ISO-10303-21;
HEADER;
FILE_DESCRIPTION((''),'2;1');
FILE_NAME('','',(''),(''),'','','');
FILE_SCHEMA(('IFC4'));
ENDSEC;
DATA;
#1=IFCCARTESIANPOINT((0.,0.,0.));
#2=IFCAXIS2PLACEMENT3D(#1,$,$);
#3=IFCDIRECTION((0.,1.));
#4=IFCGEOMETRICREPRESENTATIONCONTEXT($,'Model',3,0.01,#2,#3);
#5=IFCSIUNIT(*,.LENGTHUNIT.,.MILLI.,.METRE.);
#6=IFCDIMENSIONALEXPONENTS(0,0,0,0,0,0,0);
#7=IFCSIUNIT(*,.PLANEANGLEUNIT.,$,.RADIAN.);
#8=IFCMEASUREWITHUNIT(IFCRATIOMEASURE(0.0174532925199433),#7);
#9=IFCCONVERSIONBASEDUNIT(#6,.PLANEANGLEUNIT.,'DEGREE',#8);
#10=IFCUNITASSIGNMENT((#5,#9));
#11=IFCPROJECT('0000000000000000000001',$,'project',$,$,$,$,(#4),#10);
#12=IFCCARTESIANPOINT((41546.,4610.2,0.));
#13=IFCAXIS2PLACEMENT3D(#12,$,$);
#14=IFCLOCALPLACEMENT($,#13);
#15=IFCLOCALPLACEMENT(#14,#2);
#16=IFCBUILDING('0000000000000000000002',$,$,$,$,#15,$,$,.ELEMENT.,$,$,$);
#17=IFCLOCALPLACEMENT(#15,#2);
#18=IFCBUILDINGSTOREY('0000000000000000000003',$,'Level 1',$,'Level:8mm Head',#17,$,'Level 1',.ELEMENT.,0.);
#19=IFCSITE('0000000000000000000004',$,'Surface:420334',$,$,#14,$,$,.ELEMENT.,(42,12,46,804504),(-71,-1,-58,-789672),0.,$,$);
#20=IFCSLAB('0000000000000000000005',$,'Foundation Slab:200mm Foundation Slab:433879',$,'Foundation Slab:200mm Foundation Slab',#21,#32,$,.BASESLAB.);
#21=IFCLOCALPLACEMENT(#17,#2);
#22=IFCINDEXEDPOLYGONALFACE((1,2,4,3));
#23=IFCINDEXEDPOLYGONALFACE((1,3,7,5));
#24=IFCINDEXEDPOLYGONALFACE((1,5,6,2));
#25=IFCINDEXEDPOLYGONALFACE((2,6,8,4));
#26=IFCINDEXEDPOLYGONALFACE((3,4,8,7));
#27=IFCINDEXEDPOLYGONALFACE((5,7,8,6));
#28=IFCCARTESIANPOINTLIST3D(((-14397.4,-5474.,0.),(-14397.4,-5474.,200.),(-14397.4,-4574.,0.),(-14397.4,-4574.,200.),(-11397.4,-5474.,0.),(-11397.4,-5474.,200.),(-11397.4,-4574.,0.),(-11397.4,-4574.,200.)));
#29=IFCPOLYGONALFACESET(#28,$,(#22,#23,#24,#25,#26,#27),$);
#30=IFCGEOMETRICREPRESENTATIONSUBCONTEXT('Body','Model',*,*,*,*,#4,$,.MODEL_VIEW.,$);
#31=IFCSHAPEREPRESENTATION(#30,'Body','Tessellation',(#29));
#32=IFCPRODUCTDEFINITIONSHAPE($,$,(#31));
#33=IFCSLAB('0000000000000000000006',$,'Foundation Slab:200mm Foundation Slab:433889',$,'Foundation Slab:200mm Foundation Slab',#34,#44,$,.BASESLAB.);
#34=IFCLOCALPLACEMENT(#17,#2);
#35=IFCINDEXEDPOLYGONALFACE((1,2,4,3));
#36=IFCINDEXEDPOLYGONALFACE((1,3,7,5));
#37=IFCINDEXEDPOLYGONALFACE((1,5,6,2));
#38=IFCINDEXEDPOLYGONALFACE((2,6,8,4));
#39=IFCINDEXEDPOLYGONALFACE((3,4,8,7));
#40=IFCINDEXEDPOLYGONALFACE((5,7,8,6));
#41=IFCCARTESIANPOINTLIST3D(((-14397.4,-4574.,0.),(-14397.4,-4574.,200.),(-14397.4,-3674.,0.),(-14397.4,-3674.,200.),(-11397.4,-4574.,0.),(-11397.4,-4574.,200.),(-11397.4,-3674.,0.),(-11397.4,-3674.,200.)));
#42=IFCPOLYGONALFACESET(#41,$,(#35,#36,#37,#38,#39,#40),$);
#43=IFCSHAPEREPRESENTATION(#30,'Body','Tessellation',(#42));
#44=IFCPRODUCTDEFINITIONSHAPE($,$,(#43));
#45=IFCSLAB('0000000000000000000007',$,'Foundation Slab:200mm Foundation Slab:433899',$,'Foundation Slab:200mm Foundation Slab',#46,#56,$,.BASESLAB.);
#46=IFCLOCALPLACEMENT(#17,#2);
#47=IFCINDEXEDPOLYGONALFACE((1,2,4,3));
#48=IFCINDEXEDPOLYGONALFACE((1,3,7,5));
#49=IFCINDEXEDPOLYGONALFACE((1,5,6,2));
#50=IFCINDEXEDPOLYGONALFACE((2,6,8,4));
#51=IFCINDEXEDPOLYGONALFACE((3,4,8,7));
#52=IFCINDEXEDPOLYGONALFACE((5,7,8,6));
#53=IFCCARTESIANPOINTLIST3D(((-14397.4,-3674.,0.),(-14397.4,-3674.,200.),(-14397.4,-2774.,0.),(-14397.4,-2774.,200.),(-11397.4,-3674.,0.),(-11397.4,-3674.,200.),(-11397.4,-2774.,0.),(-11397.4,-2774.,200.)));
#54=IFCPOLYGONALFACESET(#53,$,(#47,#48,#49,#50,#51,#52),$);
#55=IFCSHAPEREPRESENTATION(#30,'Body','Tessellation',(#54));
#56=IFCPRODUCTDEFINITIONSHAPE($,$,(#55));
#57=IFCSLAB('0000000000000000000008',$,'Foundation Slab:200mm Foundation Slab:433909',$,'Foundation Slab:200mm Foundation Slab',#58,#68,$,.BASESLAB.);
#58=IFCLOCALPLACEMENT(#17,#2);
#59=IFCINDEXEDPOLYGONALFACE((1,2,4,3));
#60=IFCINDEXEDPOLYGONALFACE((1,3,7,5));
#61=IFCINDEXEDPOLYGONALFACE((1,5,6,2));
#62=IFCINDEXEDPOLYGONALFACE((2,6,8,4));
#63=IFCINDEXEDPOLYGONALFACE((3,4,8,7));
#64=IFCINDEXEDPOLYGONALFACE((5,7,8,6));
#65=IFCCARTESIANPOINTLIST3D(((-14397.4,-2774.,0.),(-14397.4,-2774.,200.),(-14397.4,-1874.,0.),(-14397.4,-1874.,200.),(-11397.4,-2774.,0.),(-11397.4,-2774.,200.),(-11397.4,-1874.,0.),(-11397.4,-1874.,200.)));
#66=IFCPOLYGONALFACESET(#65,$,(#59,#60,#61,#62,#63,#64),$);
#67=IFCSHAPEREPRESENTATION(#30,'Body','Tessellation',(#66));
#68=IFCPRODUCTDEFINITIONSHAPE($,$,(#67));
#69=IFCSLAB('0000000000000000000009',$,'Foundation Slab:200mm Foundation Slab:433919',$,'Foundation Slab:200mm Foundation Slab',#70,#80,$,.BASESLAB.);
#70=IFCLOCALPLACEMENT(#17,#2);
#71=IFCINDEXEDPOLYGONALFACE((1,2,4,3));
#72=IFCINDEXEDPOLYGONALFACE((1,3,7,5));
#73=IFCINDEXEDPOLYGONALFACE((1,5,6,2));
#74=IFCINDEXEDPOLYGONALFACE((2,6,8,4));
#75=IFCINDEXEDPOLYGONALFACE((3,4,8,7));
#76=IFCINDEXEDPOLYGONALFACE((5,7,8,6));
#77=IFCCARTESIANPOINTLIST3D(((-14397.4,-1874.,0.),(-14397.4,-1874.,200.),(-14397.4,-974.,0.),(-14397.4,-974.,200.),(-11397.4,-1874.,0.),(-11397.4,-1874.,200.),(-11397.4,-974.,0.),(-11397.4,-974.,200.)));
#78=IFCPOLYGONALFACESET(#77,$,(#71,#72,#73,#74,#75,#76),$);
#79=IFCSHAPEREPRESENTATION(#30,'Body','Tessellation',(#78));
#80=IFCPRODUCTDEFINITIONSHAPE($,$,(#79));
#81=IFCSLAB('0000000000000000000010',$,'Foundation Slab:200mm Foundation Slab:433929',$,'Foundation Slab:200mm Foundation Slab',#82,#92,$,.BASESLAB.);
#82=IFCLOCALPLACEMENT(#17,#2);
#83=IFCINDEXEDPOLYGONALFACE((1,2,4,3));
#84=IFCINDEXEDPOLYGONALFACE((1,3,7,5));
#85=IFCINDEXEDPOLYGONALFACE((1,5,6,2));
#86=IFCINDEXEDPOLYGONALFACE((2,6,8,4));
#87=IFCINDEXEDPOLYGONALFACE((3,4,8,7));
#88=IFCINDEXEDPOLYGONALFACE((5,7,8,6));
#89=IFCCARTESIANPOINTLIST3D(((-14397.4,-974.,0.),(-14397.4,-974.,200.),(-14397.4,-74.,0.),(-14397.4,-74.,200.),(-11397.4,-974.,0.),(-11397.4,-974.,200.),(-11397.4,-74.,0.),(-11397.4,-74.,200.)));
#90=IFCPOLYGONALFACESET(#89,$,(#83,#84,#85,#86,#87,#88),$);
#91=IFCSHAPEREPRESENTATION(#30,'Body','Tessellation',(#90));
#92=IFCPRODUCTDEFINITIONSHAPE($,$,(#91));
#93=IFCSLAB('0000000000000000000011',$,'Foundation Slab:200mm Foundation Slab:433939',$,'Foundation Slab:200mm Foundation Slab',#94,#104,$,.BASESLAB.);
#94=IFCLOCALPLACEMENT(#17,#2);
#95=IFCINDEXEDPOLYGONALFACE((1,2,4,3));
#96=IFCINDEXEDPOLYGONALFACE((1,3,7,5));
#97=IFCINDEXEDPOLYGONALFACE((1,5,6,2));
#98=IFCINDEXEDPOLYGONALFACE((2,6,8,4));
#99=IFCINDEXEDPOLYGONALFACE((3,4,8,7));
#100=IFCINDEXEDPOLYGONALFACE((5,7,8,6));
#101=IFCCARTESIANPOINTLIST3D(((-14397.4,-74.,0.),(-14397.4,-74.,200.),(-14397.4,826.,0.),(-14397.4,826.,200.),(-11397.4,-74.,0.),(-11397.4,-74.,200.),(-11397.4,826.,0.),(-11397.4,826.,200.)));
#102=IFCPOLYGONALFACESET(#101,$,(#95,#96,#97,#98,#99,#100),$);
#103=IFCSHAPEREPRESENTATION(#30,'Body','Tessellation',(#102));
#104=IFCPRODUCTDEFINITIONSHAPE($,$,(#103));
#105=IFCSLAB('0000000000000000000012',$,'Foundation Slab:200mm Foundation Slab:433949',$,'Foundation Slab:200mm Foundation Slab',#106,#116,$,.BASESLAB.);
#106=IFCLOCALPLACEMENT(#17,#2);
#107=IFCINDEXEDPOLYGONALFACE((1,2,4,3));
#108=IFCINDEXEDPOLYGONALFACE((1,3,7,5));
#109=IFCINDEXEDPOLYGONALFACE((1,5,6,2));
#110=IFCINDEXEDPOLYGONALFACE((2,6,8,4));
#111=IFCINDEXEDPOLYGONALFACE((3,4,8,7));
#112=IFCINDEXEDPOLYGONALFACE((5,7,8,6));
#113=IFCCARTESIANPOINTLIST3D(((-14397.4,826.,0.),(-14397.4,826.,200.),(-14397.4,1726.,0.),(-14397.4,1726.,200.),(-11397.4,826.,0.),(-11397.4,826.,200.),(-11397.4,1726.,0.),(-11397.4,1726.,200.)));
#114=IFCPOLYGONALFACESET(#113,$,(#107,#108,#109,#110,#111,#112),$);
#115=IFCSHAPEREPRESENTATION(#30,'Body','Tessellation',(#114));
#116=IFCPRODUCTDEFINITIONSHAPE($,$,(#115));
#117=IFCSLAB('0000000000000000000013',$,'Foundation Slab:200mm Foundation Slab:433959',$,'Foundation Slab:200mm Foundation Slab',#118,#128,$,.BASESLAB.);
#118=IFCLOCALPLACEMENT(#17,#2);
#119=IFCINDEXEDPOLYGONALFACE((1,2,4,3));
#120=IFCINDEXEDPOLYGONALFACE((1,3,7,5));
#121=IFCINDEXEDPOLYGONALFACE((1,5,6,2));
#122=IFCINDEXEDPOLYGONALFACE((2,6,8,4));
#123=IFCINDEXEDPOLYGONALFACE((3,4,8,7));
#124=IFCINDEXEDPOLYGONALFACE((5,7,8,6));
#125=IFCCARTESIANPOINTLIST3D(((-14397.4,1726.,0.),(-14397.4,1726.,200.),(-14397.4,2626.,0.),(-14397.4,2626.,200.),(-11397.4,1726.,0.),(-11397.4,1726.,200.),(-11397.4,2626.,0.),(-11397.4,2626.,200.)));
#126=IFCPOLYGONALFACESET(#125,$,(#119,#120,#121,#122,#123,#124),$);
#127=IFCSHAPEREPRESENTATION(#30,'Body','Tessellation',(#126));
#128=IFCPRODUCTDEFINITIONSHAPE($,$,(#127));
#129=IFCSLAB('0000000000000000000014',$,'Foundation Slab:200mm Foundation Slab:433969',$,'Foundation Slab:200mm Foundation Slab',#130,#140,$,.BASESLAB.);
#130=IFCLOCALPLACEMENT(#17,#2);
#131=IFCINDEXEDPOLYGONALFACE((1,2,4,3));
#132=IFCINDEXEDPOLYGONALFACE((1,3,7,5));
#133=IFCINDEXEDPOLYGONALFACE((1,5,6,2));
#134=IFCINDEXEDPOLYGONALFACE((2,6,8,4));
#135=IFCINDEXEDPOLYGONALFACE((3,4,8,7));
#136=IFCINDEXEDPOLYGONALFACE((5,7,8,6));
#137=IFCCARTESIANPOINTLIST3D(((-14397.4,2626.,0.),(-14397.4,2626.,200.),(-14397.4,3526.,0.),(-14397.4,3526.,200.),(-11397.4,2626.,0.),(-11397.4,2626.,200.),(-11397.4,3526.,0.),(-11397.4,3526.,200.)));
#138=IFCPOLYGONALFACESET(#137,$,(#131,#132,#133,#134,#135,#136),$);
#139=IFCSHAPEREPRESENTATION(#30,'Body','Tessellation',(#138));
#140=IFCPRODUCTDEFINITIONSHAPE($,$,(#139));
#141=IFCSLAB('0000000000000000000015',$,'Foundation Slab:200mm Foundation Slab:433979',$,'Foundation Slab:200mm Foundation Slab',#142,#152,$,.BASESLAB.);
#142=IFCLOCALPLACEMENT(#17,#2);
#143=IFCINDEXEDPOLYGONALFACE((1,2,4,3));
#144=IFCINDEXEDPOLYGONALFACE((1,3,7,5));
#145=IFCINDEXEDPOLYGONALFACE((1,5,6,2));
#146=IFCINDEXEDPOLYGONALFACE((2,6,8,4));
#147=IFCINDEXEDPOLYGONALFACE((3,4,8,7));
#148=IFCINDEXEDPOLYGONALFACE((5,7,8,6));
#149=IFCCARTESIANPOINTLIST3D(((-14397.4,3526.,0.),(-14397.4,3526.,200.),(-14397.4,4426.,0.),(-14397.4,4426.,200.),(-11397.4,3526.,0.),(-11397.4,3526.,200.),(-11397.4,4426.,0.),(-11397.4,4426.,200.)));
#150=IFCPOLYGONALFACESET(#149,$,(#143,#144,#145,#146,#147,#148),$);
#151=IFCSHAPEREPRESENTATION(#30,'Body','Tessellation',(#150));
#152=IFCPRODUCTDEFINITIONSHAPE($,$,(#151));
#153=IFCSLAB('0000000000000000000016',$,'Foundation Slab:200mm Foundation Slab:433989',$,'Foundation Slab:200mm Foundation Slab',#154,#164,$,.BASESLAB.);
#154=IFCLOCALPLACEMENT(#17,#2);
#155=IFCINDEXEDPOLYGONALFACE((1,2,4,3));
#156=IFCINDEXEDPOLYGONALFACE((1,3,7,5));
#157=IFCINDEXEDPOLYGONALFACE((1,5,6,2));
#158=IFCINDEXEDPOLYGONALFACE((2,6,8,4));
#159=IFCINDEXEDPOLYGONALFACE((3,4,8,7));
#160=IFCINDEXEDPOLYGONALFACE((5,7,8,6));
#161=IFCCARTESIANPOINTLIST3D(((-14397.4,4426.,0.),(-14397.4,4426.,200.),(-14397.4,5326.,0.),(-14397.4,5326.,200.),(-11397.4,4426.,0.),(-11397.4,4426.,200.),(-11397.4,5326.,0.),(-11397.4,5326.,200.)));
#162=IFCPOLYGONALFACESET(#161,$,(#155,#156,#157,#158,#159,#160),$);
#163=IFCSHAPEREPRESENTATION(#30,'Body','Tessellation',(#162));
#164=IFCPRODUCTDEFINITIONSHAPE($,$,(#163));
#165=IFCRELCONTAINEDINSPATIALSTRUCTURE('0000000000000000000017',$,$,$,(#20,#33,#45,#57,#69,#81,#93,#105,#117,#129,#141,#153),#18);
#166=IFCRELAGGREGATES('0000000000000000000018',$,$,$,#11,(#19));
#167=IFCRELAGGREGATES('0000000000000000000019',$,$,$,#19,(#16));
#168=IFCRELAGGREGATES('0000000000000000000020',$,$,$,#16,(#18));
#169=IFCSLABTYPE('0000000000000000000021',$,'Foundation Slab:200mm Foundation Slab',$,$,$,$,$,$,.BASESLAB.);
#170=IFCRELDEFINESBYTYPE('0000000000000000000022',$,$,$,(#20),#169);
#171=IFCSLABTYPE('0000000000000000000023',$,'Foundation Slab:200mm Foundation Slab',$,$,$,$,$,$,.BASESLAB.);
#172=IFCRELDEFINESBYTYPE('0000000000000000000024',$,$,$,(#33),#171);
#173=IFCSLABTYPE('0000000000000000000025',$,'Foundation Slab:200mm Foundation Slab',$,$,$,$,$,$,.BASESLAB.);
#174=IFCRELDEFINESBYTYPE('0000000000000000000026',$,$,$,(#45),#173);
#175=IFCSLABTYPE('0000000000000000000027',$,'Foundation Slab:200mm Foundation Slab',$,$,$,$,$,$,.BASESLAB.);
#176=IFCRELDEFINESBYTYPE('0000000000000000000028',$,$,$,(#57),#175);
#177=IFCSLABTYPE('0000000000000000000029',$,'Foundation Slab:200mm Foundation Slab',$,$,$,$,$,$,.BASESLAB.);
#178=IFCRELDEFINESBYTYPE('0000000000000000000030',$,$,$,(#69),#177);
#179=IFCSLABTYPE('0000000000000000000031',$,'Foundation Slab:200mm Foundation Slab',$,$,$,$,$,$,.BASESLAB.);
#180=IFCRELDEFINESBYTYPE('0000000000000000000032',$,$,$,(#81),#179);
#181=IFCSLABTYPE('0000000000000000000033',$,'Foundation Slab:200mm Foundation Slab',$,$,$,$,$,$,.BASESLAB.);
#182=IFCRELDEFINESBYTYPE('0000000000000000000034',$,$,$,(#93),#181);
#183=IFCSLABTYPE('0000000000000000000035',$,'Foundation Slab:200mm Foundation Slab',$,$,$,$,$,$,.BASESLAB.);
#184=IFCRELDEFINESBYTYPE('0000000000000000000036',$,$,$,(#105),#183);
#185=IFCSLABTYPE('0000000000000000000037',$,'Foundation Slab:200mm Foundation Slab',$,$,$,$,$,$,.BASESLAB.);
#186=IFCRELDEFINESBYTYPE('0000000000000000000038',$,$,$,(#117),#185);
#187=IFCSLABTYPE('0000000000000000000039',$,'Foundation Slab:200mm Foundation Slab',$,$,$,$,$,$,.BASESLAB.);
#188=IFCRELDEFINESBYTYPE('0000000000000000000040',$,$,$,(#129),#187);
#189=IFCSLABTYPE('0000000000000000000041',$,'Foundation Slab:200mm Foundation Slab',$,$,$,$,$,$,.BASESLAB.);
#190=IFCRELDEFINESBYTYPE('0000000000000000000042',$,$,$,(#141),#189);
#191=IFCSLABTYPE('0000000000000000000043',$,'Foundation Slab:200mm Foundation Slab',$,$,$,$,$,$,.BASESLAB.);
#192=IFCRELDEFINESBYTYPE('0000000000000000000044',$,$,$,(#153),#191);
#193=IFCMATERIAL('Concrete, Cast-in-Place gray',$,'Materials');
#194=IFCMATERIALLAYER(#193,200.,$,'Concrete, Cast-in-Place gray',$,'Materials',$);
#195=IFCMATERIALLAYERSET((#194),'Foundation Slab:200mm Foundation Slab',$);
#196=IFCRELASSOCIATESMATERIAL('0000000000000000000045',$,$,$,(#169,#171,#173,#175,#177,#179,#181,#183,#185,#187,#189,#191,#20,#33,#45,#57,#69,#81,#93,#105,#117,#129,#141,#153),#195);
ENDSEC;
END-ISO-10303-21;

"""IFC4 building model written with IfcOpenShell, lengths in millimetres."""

from ifc_helpers import new_model, entity, si_unit, converted_unit, direction, frame, origin, origin_2d_with_axis, place, context, subcontext, project, spatial, rectangle, extrude, material, layer, layer_set, layer_usage, type_object, element, save


model = new_model("IFC4")

# Units and contexts
model_context = context("Model", 3, precision=0.01, world=origin(), true_north=direction((0.0, 1.0)))
body_context = subcontext(model_context, "Body", "Model", "MODEL_VIEW")
ifc_project = project(units=[si_unit("LENGTHUNIT", "METRE", prefix="MILLI"), converted_unit("PLANEANGLEUNIT", "DEGREE", entity("IfcRatioMeasure", 0.0174532925199433), si_unit("PLANEANGLEUNIT", "RADIAN"), dimensions=[0, 0, 0, 0, 0, 0, 0])], contexts=[model_context])

# Site, building, storey
site_placement = place(None, frame((41546.0, 4610.2, 0.0)))
site = spatial("IfcSite", under=ifc_project, at=site_placement, Name="Surface:420334", CompositionType="ELEMENT", RefLatitude=(42, 12, 46, 804504), RefLongitude=(-71, -1, -58, -789672), RefElevation=0.0)
building_placement = place(site_placement, origin())
building = spatial("IfcBuilding", under=site, at=building_placement, CompositionType="ELEMENT")
storey_placement = place(building_placement, origin())
storey = spatial("IfcBuildingStorey", under=building, at=storey_placement, Name="Level 1", ObjectType="Level:8mm Head", LongName="Level 1", CompositionType="ELEMENT", Elevation=0.0)

# Slabs
ifc_material = material(Name="Concrete, Cast-in-Place gray", Category="Materials")
ifc_layer = layer(ifc_material, 200.0, Name="Concrete, Cast-in-Place gray", Category="Materials")
ifc_layer_set = layer_set([ifc_layer], Name="Foundation Slab:200mm Foundation Slab")
ifc_layer_usage_1 = layer_usage(ifc_layer_set, "AXIS3", "POSITIVE", 0.0)
slab_type_1 = type_object("IfcSlabType", Name="Foundation Slab:200mm Foundation Slab", PredefinedType="BASESLAB", material=ifc_layer_set)
slab_1_placement = place(storey_placement, origin())
element("IfcSlab", 1, at=slab_1_placement, inside=storey, type_object=slab_type_1, material=ifc_layer_usage_1, Name="Foundation Slab:200mm Foundation Slab:433879", ObjectType="Foundation Slab:200mm Foundation Slab", PredefinedType="BASESLAB", context=body_context, shape_type="SweptSolid", body=[
    extrude(rectangle(XDim=900.0, YDim=3000.0, at=origin_2d_with_axis()), frame((-12897.4, -5024.0, 200.0), z_axis=(0.0, 0.0, -1.0), x_axis=(0.0, 1.0, 0.0)), (0.0, 0.0, 1.0), 200.0),
])
ifc_layer_usage_2 = layer_usage(ifc_layer_set, "AXIS3", "POSITIVE", 0.0)
slab_type_2 = type_object("IfcSlabType", Name="Foundation Slab:200mm Foundation Slab", PredefinedType="BASESLAB", material=ifc_layer_set)
slab_2_placement = place(storey_placement, origin())
element("IfcSlab", 2, at=slab_2_placement, inside=storey, type_object=slab_type_2, material=ifc_layer_usage_2, Name="Foundation Slab:200mm Foundation Slab:433889", ObjectType="Foundation Slab:200mm Foundation Slab", PredefinedType="BASESLAB", context=body_context, shape_type="SweptSolid", body=[
    extrude(rectangle(XDim=900.0, YDim=3000.0, at=origin_2d_with_axis()), frame((-12897.4, -4124.0, 200.0), z_axis=(0.0, 0.0, -1.0), x_axis=(0.0, 1.0, 0.0)), (0.0, 0.0, 1.0), 200.0),
])
ifc_layer_usage_3 = layer_usage(ifc_layer_set, "AXIS3", "POSITIVE", 0.0)
slab_type_3 = type_object("IfcSlabType", Name="Foundation Slab:200mm Foundation Slab", PredefinedType="BASESLAB", material=ifc_layer_set)
slab_3_placement = place(storey_placement, origin())
element("IfcSlab", 3, at=slab_3_placement, inside=storey, type_object=slab_type_3, material=ifc_layer_usage_3, Name="Foundation Slab:200mm Foundation Slab:433899", ObjectType="Foundation Slab:200mm Foundation Slab", PredefinedType="BASESLAB", context=body_context, shape_type="SweptSolid", body=[
    extrude(rectangle(XDim=900.0, YDim=3000.0, at=origin_2d_with_axis()), frame((-12897.4, -3224.0, 200.0), z_axis=(0.0, 0.0, -1.0), x_axis=(0.0, 1.0, 0.0)), (0.0, 0.0, 1.0), 200.0),
])
ifc_layer_usage_4 = layer_usage(ifc_layer_set, "AXIS3", "POSITIVE", 0.0)
slab_type_4 = type_object("IfcSlabType", Name="Foundation Slab:200mm Foundation Slab", PredefinedType="BASESLAB", material=ifc_layer_set)
slab_4_placement = place(storey_placement, origin())
element("IfcSlab", 4, at=slab_4_placement, inside=storey, type_object=slab_type_4, material=ifc_layer_usage_4, Name="Foundation Slab:200mm Foundation Slab:433909", ObjectType="Foundation Slab:200mm Foundation Slab", PredefinedType="BASESLAB", context=body_context, shape_type="SweptSolid", body=[
    extrude(rectangle(XDim=900.0, YDim=3000.0, at=origin_2d_with_axis()), frame((-12897.4, -2324.0, 200.0), z_axis=(0.0, 0.0, -1.0), x_axis=(0.0, 1.0, 0.0)), (0.0, 0.0, 1.0), 200.0),
])
ifc_layer_usage_5 = layer_usage(ifc_layer_set, "AXIS3", "POSITIVE", 0.0)
slab_type_5 = type_object("IfcSlabType", Name="Foundation Slab:200mm Foundation Slab", PredefinedType="BASESLAB", material=ifc_layer_set)
slab_5_placement = place(storey_placement, origin())
element("IfcSlab", 5, at=slab_5_placement, inside=storey, type_object=slab_type_5, material=ifc_layer_usage_5, Name="Foundation Slab:200mm Foundation Slab:433919", ObjectType="Foundation Slab:200mm Foundation Slab", PredefinedType="BASESLAB", context=body_context, shape_type="SweptSolid", body=[
    extrude(rectangle(XDim=900.0, YDim=3000.0, at=origin_2d_with_axis()), frame((-12897.4, -1424.0, 200.0), z_axis=(0.0, 0.0, -1.0), x_axis=(0.0, 1.0, 0.0)), (0.0, 0.0, 1.0), 200.0),
])
ifc_layer_usage_6 = layer_usage(ifc_layer_set, "AXIS3", "POSITIVE", 0.0)
slab_type_6 = type_object("IfcSlabType", Name="Foundation Slab:200mm Foundation Slab", PredefinedType="BASESLAB", material=ifc_layer_set)
slab_6_placement = place(storey_placement, origin())
element("IfcSlab", 6, at=slab_6_placement, inside=storey, type_object=slab_type_6, material=ifc_layer_usage_6, Name="Foundation Slab:200mm Foundation Slab:433929", ObjectType="Foundation Slab:200mm Foundation Slab", PredefinedType="BASESLAB", context=body_context, shape_type="SweptSolid", body=[
    extrude(rectangle(XDim=900.0, YDim=3000.0, at=origin_2d_with_axis()), frame((-12897.4, -524.0, 200.0), z_axis=(0.0, 0.0, -1.0), x_axis=(0.0, 1.0, 0.0)), (0.0, 0.0, 1.0), 200.0),
])
ifc_layer_usage_7 = layer_usage(ifc_layer_set, "AXIS3", "POSITIVE", 0.0)
slab_type_7 = type_object("IfcSlabType", Name="Foundation Slab:200mm Foundation Slab", PredefinedType="BASESLAB", material=ifc_layer_set)
slab_7_placement = place(storey_placement, origin())
element("IfcSlab", 7, at=slab_7_placement, inside=storey, type_object=slab_type_7, material=ifc_layer_usage_7, Name="Foundation Slab:200mm Foundation Slab:433939", ObjectType="Foundation Slab:200mm Foundation Slab", PredefinedType="BASESLAB", context=body_context, shape_type="SweptSolid", body=[
    extrude(rectangle(XDim=900.0, YDim=3000.0, at=origin_2d_with_axis()), frame((-12897.4, 376.0, 200.0), z_axis=(0.0, 0.0, -1.0), x_axis=(0.0, 1.0, 0.0)), (0.0, 0.0, 1.0), 200.0),
])
ifc_layer_usage_8 = layer_usage(ifc_layer_set, "AXIS3", "POSITIVE", 0.0)
slab_type_8 = type_object("IfcSlabType", Name="Foundation Slab:200mm Foundation Slab", PredefinedType="BASESLAB", material=ifc_layer_set)
slab_8_placement = place(storey_placement, origin())
element("IfcSlab", 8, at=slab_8_placement, inside=storey, type_object=slab_type_8, material=ifc_layer_usage_8, Name="Foundation Slab:200mm Foundation Slab:433949", ObjectType="Foundation Slab:200mm Foundation Slab", PredefinedType="BASESLAB", context=body_context, shape_type="SweptSolid", body=[
    extrude(rectangle(XDim=900.0, YDim=3000.0, at=origin_2d_with_axis()), frame((-12897.4, 1276.0, 200.0), z_axis=(0.0, 0.0, -1.0), x_axis=(0.0, 1.0, 0.0)), (0.0, 0.0, 1.0), 200.0),
])
ifc_layer_usage_9 = layer_usage(ifc_layer_set, "AXIS3", "POSITIVE", 0.0)
slab_type_9 = type_object("IfcSlabType", Name="Foundation Slab:200mm Foundation Slab", PredefinedType="BASESLAB", material=ifc_layer_set)
slab_9_placement = place(storey_placement, origin())
element("IfcSlab", 9, at=slab_9_placement, inside=storey, type_object=slab_type_9, material=ifc_layer_usage_9, Name="Foundation Slab:200mm Foundation Slab:433959", ObjectType="Foundation Slab:200mm Foundation Slab", PredefinedType="BASESLAB", context=body_context, shape_type="SweptSolid", body=[
    extrude(rectangle(XDim=900.0, YDim=3000.0, at=origin_2d_with_axis()), frame((-12897.4, 2176.0, 200.0), z_axis=(0.0, 0.0, -1.0), x_axis=(0.0, 1.0, 0.0)), (0.0, 0.0, 1.0), 200.0),
])
ifc_layer_usage_10 = layer_usage(ifc_layer_set, "AXIS3", "POSITIVE", 0.0)
slab_type_10 = type_object("IfcSlabType", Name="Foundation Slab:200mm Foundation Slab", PredefinedType="BASESLAB", material=ifc_layer_set)
slab_10_placement = place(storey_placement, origin())
element("IfcSlab", 10, at=slab_10_placement, inside=storey, type_object=slab_type_10, material=ifc_layer_usage_10, Name="Foundation Slab:200mm Foundation Slab:433969", ObjectType="Foundation Slab:200mm Foundation Slab", PredefinedType="BASESLAB", context=body_context, shape_type="SweptSolid", body=[
    extrude(rectangle(XDim=900.0, YDim=3000.0, at=origin_2d_with_axis()), frame((-12897.4, 3076.0, 200.0), z_axis=(0.0, 0.0, -1.0), x_axis=(0.0, 1.0, 0.0)), (0.0, 0.0, 1.0), 200.0),
])
ifc_layer_usage_11 = layer_usage(ifc_layer_set, "AXIS3", "POSITIVE", 0.0)
slab_type_11 = type_object("IfcSlabType", Name="Foundation Slab:200mm Foundation Slab", PredefinedType="BASESLAB", material=ifc_layer_set)
slab_11_placement = place(storey_placement, origin())
element("IfcSlab", 11, at=slab_11_placement, inside=storey, type_object=slab_type_11, material=ifc_layer_usage_11, Name="Foundation Slab:200mm Foundation Slab:433979", ObjectType="Foundation Slab:200mm Foundation Slab", PredefinedType="BASESLAB", context=body_context, shape_type="SweptSolid", body=[
    extrude(rectangle(XDim=900.0, YDim=3000.0, at=origin_2d_with_axis()), frame((-12897.4, 3976.0, 200.0), z_axis=(0.0, 0.0, -1.0), x_axis=(0.0, 1.0, 0.0)), (0.0, 0.0, 1.0), 200.0),
])
ifc_layer_usage_12 = layer_usage(ifc_layer_set, "AXIS3", "POSITIVE", 0.0)
slab_type_12 = type_object("IfcSlabType", Name="Foundation Slab:200mm Foundation Slab", PredefinedType="BASESLAB", material=ifc_layer_set)
slab_12_placement = place(storey_placement, origin())
element("IfcSlab", 12, at=slab_12_placement, inside=storey, type_object=slab_type_12, material=ifc_layer_usage_12, Name="Foundation Slab:200mm Foundation Slab:433989", ObjectType="Foundation Slab:200mm Foundation Slab", PredefinedType="BASESLAB", context=body_context, shape_type="SweptSolid", body=[
    extrude(rectangle(XDim=900.0, YDim=3000.0, at=origin_2d_with_axis()), frame((-12897.4, 4876.0, 200.0), z_axis=(0.0, 0.0, -1.0), x_axis=(0.0, 1.0, 0.0)), (0.0, 0.0, 1.0), 200.0),
])

save(model, "model.ifc")
